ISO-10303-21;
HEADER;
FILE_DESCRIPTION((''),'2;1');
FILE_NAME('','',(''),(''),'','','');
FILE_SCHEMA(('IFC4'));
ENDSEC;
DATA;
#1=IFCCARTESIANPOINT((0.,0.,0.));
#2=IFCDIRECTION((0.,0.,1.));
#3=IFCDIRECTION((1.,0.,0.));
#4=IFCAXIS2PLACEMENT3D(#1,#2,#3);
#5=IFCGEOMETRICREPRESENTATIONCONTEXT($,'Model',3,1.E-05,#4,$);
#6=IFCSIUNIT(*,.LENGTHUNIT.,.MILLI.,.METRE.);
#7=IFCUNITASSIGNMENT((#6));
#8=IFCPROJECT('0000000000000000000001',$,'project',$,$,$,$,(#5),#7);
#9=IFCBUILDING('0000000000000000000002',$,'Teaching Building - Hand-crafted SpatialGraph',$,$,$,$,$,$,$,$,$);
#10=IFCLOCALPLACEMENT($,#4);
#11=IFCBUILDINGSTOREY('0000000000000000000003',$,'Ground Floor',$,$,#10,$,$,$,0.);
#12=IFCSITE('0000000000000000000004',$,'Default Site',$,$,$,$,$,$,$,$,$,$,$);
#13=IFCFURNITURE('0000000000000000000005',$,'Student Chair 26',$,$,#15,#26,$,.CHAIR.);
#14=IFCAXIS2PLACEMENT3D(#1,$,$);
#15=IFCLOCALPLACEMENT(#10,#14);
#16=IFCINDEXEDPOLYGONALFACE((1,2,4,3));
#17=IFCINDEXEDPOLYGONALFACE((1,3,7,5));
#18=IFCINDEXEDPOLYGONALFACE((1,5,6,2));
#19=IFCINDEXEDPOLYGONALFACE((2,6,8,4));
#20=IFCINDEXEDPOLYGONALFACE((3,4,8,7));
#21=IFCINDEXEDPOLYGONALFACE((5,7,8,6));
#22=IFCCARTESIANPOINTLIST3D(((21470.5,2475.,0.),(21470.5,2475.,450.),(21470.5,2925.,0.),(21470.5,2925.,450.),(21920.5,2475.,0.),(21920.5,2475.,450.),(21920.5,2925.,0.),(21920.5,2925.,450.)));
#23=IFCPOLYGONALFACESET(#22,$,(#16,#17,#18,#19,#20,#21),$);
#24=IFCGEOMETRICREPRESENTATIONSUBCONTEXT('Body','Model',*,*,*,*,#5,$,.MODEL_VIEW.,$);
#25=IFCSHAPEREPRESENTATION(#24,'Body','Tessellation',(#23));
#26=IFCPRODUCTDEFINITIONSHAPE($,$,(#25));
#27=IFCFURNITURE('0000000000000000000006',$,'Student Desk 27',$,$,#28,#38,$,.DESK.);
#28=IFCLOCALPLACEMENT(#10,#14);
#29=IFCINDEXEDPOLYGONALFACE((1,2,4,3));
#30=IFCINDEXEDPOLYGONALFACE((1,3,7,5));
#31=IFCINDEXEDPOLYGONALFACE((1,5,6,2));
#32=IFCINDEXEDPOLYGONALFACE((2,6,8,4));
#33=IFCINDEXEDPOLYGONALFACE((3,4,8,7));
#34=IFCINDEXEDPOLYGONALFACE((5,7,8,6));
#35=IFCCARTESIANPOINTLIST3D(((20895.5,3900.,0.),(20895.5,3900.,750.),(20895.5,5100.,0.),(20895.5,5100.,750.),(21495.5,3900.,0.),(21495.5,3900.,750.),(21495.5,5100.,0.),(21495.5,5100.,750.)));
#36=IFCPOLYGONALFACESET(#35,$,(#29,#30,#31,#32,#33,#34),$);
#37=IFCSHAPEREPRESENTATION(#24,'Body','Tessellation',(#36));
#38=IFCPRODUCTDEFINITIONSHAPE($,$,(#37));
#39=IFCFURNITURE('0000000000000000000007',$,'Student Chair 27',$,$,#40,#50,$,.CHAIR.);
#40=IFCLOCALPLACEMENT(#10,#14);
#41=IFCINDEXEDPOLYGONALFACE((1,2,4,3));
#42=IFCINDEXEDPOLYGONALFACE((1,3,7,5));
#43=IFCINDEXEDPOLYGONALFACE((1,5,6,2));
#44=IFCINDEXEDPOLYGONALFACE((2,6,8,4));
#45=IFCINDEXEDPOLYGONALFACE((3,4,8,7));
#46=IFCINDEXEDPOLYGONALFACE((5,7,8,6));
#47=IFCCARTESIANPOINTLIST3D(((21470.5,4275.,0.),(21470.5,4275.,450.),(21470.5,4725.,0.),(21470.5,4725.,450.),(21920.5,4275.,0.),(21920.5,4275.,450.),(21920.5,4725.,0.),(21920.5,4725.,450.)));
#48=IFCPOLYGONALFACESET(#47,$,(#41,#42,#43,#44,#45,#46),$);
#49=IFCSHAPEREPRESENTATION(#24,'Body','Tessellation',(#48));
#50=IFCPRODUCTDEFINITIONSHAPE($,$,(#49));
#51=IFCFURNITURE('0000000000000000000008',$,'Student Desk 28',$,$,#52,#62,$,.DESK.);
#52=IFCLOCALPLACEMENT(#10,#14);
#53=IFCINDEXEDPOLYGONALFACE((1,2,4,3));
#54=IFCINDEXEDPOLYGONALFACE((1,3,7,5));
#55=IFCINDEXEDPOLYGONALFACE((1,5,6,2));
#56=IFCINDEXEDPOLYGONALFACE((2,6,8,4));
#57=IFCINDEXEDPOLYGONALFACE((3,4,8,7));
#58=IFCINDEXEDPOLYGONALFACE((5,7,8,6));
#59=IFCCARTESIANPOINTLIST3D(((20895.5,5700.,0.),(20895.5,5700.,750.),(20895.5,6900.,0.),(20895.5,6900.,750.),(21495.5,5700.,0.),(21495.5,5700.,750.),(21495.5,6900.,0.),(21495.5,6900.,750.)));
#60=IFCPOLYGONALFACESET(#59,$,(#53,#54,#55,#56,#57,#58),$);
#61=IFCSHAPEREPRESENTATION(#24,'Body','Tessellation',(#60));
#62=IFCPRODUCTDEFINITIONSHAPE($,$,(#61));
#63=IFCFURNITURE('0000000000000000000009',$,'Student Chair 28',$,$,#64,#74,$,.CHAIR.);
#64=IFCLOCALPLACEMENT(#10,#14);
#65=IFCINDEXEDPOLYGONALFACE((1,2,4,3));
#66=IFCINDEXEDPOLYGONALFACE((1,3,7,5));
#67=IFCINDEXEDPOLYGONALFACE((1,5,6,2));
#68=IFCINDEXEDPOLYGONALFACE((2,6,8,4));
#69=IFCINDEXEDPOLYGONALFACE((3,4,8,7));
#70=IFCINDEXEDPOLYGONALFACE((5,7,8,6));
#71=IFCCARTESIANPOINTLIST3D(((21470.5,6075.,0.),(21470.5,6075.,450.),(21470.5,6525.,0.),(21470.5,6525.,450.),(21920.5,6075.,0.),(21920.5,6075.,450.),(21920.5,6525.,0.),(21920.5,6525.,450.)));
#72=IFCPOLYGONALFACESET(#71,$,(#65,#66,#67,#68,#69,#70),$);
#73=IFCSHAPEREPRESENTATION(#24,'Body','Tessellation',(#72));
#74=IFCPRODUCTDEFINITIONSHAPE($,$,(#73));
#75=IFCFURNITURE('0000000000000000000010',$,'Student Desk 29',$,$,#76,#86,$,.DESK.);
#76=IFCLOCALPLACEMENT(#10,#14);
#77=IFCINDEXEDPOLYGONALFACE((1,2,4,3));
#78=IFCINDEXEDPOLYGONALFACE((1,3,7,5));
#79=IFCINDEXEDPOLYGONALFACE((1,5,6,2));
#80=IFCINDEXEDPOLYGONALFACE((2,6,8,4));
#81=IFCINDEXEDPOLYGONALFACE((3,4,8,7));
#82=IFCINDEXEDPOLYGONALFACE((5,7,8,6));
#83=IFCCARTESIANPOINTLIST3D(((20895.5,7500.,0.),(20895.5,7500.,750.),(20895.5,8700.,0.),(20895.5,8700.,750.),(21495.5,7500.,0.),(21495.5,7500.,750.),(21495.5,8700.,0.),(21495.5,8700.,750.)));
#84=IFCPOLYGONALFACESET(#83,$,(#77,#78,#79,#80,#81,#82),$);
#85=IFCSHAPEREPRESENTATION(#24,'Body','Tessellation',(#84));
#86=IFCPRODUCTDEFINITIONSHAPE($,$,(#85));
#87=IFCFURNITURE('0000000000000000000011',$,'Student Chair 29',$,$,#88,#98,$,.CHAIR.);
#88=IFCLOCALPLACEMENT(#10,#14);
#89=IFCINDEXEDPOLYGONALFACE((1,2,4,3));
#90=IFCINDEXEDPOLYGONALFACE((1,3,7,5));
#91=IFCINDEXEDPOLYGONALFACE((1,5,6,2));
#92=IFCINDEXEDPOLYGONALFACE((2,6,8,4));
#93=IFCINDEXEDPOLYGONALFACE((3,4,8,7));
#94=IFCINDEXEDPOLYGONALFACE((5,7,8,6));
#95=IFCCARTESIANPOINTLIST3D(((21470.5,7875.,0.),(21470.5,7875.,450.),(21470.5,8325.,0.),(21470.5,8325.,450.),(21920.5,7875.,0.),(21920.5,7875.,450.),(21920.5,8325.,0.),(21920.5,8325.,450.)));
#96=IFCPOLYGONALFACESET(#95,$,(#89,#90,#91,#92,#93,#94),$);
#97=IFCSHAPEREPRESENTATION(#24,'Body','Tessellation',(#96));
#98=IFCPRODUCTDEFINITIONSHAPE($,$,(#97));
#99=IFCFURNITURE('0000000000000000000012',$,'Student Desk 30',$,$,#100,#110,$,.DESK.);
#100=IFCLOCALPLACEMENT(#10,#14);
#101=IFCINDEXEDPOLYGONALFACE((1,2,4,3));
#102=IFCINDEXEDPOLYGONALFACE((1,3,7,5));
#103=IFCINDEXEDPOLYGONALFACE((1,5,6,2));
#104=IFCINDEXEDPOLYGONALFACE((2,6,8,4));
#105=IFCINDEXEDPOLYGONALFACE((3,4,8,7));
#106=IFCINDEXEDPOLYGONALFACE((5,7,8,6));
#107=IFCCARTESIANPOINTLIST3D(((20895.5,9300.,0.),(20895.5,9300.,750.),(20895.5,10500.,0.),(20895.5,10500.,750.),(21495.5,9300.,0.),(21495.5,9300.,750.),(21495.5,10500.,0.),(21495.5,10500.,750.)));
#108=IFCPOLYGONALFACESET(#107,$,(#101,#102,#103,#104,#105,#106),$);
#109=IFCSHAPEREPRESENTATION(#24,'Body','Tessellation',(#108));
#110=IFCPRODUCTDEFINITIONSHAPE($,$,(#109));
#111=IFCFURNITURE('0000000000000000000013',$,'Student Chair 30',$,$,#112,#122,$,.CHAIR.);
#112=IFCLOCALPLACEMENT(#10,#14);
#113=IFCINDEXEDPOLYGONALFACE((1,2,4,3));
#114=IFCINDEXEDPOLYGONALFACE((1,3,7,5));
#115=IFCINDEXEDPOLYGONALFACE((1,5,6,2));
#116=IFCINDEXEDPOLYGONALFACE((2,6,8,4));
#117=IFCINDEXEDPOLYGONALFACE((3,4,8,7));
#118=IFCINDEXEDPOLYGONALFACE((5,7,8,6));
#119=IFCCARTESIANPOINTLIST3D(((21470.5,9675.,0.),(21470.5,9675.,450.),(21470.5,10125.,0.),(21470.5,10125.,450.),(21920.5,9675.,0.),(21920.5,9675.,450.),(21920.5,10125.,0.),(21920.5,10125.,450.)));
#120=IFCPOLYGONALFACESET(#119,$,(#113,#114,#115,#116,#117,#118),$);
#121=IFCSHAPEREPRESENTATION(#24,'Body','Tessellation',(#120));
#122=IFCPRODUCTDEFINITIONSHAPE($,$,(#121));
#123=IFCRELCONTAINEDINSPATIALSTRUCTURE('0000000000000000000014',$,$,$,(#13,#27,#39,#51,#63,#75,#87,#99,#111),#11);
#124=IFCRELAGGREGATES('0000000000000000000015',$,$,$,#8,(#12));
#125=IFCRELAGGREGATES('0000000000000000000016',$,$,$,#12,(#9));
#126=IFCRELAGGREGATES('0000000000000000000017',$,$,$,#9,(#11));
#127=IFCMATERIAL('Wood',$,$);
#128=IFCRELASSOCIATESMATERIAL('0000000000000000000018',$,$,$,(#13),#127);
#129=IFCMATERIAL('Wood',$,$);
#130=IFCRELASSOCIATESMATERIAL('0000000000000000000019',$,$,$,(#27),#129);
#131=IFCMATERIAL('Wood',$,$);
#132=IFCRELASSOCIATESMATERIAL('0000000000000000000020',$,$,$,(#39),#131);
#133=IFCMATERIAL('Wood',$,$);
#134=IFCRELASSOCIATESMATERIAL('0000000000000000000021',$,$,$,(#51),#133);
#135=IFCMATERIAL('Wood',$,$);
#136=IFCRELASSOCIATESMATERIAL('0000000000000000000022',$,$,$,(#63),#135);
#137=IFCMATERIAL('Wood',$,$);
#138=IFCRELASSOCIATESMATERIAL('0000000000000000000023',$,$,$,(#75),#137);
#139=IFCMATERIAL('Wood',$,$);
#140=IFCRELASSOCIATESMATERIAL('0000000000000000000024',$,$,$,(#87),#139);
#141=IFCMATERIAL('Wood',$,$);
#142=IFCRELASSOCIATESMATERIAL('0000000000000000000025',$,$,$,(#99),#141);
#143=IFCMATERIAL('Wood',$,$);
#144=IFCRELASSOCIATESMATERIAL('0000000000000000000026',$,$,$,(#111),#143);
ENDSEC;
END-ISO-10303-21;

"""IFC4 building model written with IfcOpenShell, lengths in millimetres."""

from ifc_helpers import new_model, si_unit, frame, origin_with_axes, origin_2d, place, context, subcontext, project, spatial, rectangle, extrude, material, element, save


model = new_model("IFC4")

# Units and contexts
model_context = context("Model", 3, precision=1e-05, world=origin_with_axes())
body_context = subcontext(model_context, "Body", "Model", "MODEL_VIEW")
ifc_project = project(units=[si_unit("LENGTHUNIT", "METRE", prefix="MILLI")], contexts=[model_context])

# Site, building, storey
site = spatial("IfcSite", under=ifc_project, Name="Default Site")
building = spatial("IfcBuilding", under=site, Name="Teaching Building - Hand-crafted SpatialGraph")
storey_placement = place(None, origin_with_axes())
storey = spatial("IfcBuildingStorey", under=building, at=storey_placement, Name="Ground Floor", Elevation=0.0)

# Furniture
ifc_material_1 = material(Name="Wood")
furniture_1_placement = place(storey_placement, frame((21695.5, 2700.0, 0.0), z_axis=(0.0, 0.0, 1.0), x_axis=(1.0, 0.0, 0.0)))
element("IfcFurniture", 1, at=furniture_1_placement, inside=storey, material=ifc_material_1, Name="Student Chair 26", PredefinedType="CHAIR", context=body_context, shape_type="SweptSolid", body=[
    extrude(rectangle(XDim=450.0, YDim=450.0, at=origin_2d()), origin_with_axes(), (0.0, 0.0, 1.0), 450.0),
])
ifc_material_2 = material(Name="Wood")
furniture_2_placement = place(storey_placement, frame((21195.5, 4500.0, 0.0), z_axis=(0.0, 0.0, 1.0), x_axis=(0.0, 1.0, 0.0)))
element("IfcFurniture", 2, at=furniture_2_placement, inside=storey, material=ifc_material_2, Name="Student Desk 27", PredefinedType="DESK", context=body_context, shape_type="SweptSolid", body=[
    extrude(rectangle(XDim=1200.0, YDim=600.0, at=origin_2d()), origin_with_axes(), (0.0, 0.0, 1.0), 750.0),
])
ifc_material_3 = material(Name="Wood")
furniture_3_placement = place(storey_placement, frame((21695.5, 4500.0, 0.0), z_axis=(0.0, 0.0, 1.0), x_axis=(1.0, 0.0, 0.0)))
element("IfcFurniture", 3, at=furniture_3_placement, inside=storey, material=ifc_material_3, Name="Student Chair 27", PredefinedType="CHAIR", context=body_context, shape_type="SweptSolid", body=[
    extrude(rectangle(XDim=450.0, YDim=450.0, at=origin_2d()), origin_with_axes(), (0.0, 0.0, 1.0), 450.0),
])
ifc_material_4 = material(Name="Wood")
furniture_4_placement = place(storey_placement, frame((21195.5, 6300.0, 0.0), z_axis=(0.0, 0.0, 1.0), x_axis=(0.0, 1.0, 0.0)))
element("IfcFurniture", 4, at=furniture_4_placement, inside=storey, material=ifc_material_4, Name="Student Desk 28", PredefinedType="DESK", context=body_context, shape_type="SweptSolid", body=[
    extrude(rectangle(XDim=1200.0, YDim=600.0, at=origin_2d()), origin_with_axes(), (0.0, 0.0, 1.0), 750.0),
])
ifc_material_5 = material(Name="Wood")
furniture_5_placement = place(storey_placement, frame((21695.5, 6300.0, 0.0), z_axis=(0.0, 0.0, 1.0), x_axis=(1.0, 0.0, 0.0)))
element("IfcFurniture", 5, at=furniture_5_placement, inside=storey, material=ifc_material_5, Name="Student Chair 28", PredefinedType="CHAIR", context=body_context, shape_type="SweptSolid", body=[
    extrude(rectangle(XDim=450.0, YDim=450.0, at=origin_2d()), origin_with_axes(), (0.0, 0.0, 1.0), 450.0),
])
ifc_material_6 = material(Name="Wood")
furniture_6_placement = place(storey_placement, frame((21195.5, 8100.0, 0.0), z_axis=(0.0, 0.0, 1.0), x_axis=(0.0, 1.0, 0.0)))
element("IfcFurniture", 6, at=furniture_6_placement, inside=storey, material=ifc_material_6, Name="Student Desk 29", PredefinedType="DESK", context=body_context, shape_type="SweptSolid", body=[
    extrude(rectangle(XDim=1200.0, YDim=600.0, at=origin_2d()), origin_with_axes(), (0.0, 0.0, 1.0), 750.0),
])
ifc_material_7 = material(Name="Wood")
furniture_7_placement = place(storey_placement, frame((21695.5, 8100.0, 0.0), z_axis=(0.0, 0.0, 1.0), x_axis=(1.0, 0.0, 0.0)))
element("IfcFurniture", 7, at=furniture_7_placement, inside=storey, material=ifc_material_7, Name="Student Chair 29", PredefinedType="CHAIR", context=body_context, shape_type="SweptSolid", body=[
    extrude(rectangle(XDim=450.0, YDim=450.0, at=origin_2d()), origin_with_axes(), (0.0, 0.0, 1.0), 450.0),
])
ifc_material_8 = material(Name="Wood")
furniture_8_placement = place(storey_placement, frame((21195.5, 9900.0, 0.0), z_axis=(0.0, 0.0, 1.0), x_axis=(0.0, 1.0, 0.0)))
element("IfcFurniture", 8, at=furniture_8_placement, inside=storey, material=ifc_material_8, Name="Student Desk 30", PredefinedType="DESK", context=body_context, shape_type="SweptSolid", body=[
    extrude(rectangle(XDim=1200.0, YDim=600.0, at=origin_2d()), origin_with_axes(), (0.0, 0.0, 1.0), 750.0),
])
ifc_material_9 = material(Name="Wood")
furniture_9_placement = place(storey_placement, frame((21695.5, 9900.0, 0.0), z_axis=(0.0, 0.0, 1.0), x_axis=(1.0, 0.0, 0.0)))
element("IfcFurniture", 9, at=furniture_9_placement, inside=storey, material=ifc_material_9, Name="Student Chair 30", PredefinedType="CHAIR", context=body_context, shape_type="SweptSolid", body=[
    extrude(rectangle(XDim=450.0, YDim=450.0, at=origin_2d()), origin_with_axes(), (0.0, 0.0, 1.0), 450.0),
])

save(model, "model.ifc")
